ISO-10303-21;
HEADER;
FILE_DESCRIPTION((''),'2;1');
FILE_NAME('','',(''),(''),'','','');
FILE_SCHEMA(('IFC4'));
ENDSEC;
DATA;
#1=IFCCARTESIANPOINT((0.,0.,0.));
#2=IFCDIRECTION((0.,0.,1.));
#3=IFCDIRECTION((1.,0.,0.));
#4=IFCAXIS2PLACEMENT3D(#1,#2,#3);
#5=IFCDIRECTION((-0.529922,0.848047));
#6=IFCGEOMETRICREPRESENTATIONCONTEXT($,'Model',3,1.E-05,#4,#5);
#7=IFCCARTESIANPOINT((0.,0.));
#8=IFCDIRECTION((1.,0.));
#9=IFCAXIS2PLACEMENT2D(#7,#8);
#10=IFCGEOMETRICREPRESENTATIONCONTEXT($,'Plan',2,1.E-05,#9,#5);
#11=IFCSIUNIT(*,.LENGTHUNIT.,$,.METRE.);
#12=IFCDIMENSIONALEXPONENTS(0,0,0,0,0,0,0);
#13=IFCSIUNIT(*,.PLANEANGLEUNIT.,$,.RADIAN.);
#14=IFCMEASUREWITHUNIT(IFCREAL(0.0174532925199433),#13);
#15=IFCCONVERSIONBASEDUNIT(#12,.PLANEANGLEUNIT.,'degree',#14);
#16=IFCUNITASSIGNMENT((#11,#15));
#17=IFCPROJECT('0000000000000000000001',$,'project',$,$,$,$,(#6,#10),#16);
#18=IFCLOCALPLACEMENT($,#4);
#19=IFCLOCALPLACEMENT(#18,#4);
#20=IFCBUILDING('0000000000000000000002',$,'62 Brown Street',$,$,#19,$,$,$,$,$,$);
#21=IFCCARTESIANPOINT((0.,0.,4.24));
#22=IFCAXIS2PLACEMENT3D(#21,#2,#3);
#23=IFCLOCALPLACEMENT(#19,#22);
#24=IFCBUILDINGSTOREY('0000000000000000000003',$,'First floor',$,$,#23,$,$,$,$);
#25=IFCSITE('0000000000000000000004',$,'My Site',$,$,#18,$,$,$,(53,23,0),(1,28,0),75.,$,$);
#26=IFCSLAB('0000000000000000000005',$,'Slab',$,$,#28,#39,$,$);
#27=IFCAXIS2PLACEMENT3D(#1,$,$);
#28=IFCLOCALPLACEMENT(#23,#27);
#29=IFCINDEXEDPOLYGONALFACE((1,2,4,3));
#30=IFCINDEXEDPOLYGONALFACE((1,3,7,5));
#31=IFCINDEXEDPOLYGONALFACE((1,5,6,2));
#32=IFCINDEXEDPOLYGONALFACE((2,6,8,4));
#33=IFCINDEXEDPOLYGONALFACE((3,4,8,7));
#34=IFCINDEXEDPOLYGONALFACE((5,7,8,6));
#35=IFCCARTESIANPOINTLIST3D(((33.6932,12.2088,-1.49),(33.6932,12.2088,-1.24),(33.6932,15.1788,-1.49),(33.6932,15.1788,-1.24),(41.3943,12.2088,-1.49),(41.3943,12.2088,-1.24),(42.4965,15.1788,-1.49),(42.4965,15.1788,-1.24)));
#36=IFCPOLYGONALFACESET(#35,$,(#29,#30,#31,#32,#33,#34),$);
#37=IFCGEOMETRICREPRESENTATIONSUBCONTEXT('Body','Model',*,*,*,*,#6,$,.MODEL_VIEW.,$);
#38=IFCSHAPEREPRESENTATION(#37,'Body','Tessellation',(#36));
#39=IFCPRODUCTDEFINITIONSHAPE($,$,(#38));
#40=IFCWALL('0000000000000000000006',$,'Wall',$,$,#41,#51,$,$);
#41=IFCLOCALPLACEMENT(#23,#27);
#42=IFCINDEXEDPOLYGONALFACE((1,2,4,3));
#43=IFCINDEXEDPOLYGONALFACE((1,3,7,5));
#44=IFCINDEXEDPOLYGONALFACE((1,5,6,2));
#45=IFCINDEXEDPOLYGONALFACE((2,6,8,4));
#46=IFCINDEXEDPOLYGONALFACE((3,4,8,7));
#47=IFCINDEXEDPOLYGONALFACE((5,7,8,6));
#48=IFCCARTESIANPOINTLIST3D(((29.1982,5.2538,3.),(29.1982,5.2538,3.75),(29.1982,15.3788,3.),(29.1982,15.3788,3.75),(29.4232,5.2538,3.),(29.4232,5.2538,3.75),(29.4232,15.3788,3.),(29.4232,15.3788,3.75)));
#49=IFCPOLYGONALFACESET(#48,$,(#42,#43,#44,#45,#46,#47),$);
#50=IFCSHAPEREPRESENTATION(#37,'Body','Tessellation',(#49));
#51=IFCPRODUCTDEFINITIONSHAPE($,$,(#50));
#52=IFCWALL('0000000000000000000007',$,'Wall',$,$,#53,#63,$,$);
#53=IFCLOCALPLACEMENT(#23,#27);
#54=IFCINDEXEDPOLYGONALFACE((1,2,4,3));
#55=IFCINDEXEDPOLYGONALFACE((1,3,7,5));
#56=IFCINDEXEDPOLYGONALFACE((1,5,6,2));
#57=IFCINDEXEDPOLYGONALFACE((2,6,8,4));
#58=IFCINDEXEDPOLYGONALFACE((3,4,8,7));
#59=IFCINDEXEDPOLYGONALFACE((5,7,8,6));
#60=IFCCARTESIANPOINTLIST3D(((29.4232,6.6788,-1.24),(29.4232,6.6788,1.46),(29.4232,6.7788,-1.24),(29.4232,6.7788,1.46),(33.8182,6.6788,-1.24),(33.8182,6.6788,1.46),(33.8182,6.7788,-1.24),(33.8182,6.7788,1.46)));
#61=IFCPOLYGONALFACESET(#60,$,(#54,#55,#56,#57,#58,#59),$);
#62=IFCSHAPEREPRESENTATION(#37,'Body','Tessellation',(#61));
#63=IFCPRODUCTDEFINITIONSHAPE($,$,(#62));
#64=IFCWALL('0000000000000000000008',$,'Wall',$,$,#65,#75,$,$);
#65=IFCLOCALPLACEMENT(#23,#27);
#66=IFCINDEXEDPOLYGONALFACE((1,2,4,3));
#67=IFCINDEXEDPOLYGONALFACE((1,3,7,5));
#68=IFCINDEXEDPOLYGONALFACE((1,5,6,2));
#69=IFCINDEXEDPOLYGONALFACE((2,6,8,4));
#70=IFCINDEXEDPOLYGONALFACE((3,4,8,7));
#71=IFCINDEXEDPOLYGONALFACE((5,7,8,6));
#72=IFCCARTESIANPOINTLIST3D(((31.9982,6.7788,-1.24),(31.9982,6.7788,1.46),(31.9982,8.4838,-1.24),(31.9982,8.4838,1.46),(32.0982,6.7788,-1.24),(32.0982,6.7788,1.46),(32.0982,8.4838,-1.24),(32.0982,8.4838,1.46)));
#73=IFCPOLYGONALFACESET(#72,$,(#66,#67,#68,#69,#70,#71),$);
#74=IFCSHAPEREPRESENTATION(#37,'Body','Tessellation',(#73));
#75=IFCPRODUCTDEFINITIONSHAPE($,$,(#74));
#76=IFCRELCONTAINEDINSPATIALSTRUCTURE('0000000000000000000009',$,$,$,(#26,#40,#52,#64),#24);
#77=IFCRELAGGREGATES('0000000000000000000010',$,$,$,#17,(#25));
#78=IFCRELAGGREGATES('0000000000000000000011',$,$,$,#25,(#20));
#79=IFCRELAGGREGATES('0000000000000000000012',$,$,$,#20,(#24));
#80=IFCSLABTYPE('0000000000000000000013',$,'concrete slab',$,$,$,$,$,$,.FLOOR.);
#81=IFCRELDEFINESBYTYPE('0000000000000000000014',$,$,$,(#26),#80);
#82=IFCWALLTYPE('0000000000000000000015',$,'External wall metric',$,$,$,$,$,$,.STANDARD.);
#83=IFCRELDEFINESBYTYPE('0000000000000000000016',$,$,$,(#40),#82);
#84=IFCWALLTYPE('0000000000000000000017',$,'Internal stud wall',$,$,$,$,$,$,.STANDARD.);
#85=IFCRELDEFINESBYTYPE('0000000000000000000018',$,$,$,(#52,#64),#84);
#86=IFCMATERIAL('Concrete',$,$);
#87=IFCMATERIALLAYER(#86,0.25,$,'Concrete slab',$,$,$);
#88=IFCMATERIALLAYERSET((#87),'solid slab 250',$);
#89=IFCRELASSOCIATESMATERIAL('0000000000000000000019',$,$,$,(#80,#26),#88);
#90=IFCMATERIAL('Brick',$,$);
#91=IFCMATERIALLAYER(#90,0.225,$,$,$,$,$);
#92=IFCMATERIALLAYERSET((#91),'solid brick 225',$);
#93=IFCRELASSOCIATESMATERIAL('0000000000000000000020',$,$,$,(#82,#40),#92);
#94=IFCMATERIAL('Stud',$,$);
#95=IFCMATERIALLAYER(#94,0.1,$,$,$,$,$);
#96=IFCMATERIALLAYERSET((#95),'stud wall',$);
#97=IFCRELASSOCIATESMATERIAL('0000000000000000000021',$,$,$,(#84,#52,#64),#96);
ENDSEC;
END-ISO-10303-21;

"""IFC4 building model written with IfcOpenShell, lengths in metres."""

from ifc_helpers import new_model, entity, si_unit, converted_unit, direction, frame, origin_with_axes, origin_2d_with_axis, place, context, subcontext, project, spatial, line, indexed_curve, outline, extrude, material, layer, layer_set, layer_usage, type_object, element, save


model = new_model("IFC4")

# Units and contexts
model_context = context("Model", 3, precision=1e-05, world=origin_with_axes(), true_north=direction((-0.529922, 0.848047)))
plan_context = context("Plan", 2, precision=1e-05, world=origin_2d_with_axis(), true_north=direction((-0.529922, 0.848047)))
body_context_1 = subcontext(model_context, "Body", "Model", "MODEL_VIEW")
ifc_project = project(units=[si_unit("LENGTHUNIT", "METRE"), converted_unit("PLANEANGLEUNIT", "degree", entity("IfcReal", 0.0174532925199433), si_unit("PLANEANGLEUNIT", "RADIAN"), dimensions=[0, 0, 0, 0, 0, 0, 0])], contexts=[model_context, plan_context])

# Site, building, storey
site_placement = place(None, origin_with_axes())
site = spatial("IfcSite", under=ifc_project, at=site_placement, Name="My Site", RefLatitude=(53, 23, 0), RefLongitude=(1, 28, 0), RefElevation=75.0)
building_placement = place(site_placement, origin_with_axes())
building = spatial("IfcBuilding", under=site, at=building_placement, Name="62 Brown Street")
storey_placement = place(building_placement, frame((0.0, 0.0, 4.24), z_axis=(0.0, 0.0, 1.0), x_axis=(1.0, 0.0, 0.0)))
storey = spatial("IfcBuildingStorey", under=building, at=storey_placement, Name="First floor")

# Slab
ifc_material_1 = material(Name="Concrete")
ifc_layer_1 = layer(ifc_material_1, 0.25, Name="Concrete slab")
ifc_layer_set_1 = layer_set([ifc_layer_1], Name="solid slab 250")
ifc_layer_usage_1 = layer_usage(ifc_layer_set_1, "AXIS3", "POSITIVE", 0.0)
slab_type = type_object("IfcSlabType", Name="concrete slab", PredefinedType="FLOOR", material=ifc_layer_set_1)
slab_1_placement = place(storey_placement, frame((33.6932, 12.2088, -1.49), z_axis=(0.0, 0.0, 1.0), x_axis=(1.0, 0.0, 0.0)))
element("IfcSlab", 1, at=slab_1_placement, inside=storey, type_object=slab_type, material=ifc_layer_usage_1, Name="Slab", context=body_context_1, shape_type="SweptSolid", body=[
    extrude(outline(indexed_curve([(8.8033, 2.97), (7.7011, 0.0), (0.0, 0.0), (0.0, 2.97)], segments=[line(4, 1), line(1, 2), line(2, 3), line(3, 4)], self_intersect=False)), None, (0.0, 0.0, 1.0), 0.25),
])

# Shared definitions
ifc_material_2 = material(Name="Brick")
ifc_layer_2 = layer(ifc_material_2, 0.225)
ifc_layer_set_2 = layer_set([ifc_layer_2], Name="solid brick 225")
wall_type_1 = type_object("IfcWallType", Name="External wall metric", PredefinedType="STANDARD", material=ifc_layer_set_2)

# Wall
ifc_layer_usage_2 = layer_usage(ifc_layer_set_2, "AXIS2", "POSITIVE", 0.0)
wall_1_placement = place(storey_placement, frame((29.4232, 5.2538, 3.0), z_axis=(0.0, 0.0, 1.0), x_axis=(0.0, 1.0, 0.0)))
element("IfcWall", 2, at=wall_1_placement, inside=storey, type_object=wall_type_1, material=ifc_layer_usage_2, Name="Wall", context=body_context_1, shape_type="SweptSolid", body=[
    extrude(outline(indexed_curve([(0.0, 0.0), (0.0, 0.225), (10.125, 0.225), (10.125, 0.0), (0.0, 0.0)], self_intersect=False)), origin_with_axes(), (0.0, 0.0, 1.0), 0.75),
])

# Shared definitions
ifc_material_3 = material(Name="Stud")
ifc_layer_3 = layer(ifc_material_3, 0.1)
ifc_layer_set_3 = layer_set([ifc_layer_3], Name="stud wall")
wall_type_2 = type_object("IfcWallType", Name="Internal stud wall", PredefinedType="STANDARD", material=ifc_layer_set_3)

# Walls
ifc_layer_usage_3 = layer_usage(ifc_layer_set_3, "AXIS2", "POSITIVE", 0.0)
wall_2_placement = place(storey_placement, frame((33.8182, 6.7788, -1.24), z_axis=(0.0, 0.0, 1.0), x_axis=(-1.0, 0.000001, 0.0)))
element("IfcWall", 3, at=wall_2_placement, inside=storey, type_object=wall_type_2, material=ifc_layer_usage_3, Name="Wall", context=body_context_1, shape_type="SweptSolid", body=[
    extrude(outline(indexed_curve([(0.0, 0.0), (0.0, 0.1), (4.395, 0.1), (4.395, 0.0), (0.0, 0.0)], self_intersect=False)), origin_with_axes(), (0.0, 0.0, 1.0), 2.7),
])
ifc_layer_usage_4 = layer_usage(ifc_layer_set_3, "AXIS2", "POSITIVE", 0.0)
wall_3_placement = place(storey_placement, frame((32.0982, 6.7788, -1.24), z_axis=(0.0, 0.0, 1.0), x_axis=(0.000001, 1.0, 0.0)))
element("IfcWall", 4, at=wall_3_placement, inside=storey, type_object=wall_type_2, material=ifc_layer_usage_4, Name="Wall", context=body_context_1, shape_type="SweptSolid", body=[
    extrude(outline(indexed_curve([(0.0, 0.0), (0.0, 0.1), (1.705, 0.1), (1.705, 0.0), (0.0, 0.0)], self_intersect=False)), origin_with_axes(), (0.0, 0.0, 1.0), 2.7),
])

save(model, "model.ifc")
